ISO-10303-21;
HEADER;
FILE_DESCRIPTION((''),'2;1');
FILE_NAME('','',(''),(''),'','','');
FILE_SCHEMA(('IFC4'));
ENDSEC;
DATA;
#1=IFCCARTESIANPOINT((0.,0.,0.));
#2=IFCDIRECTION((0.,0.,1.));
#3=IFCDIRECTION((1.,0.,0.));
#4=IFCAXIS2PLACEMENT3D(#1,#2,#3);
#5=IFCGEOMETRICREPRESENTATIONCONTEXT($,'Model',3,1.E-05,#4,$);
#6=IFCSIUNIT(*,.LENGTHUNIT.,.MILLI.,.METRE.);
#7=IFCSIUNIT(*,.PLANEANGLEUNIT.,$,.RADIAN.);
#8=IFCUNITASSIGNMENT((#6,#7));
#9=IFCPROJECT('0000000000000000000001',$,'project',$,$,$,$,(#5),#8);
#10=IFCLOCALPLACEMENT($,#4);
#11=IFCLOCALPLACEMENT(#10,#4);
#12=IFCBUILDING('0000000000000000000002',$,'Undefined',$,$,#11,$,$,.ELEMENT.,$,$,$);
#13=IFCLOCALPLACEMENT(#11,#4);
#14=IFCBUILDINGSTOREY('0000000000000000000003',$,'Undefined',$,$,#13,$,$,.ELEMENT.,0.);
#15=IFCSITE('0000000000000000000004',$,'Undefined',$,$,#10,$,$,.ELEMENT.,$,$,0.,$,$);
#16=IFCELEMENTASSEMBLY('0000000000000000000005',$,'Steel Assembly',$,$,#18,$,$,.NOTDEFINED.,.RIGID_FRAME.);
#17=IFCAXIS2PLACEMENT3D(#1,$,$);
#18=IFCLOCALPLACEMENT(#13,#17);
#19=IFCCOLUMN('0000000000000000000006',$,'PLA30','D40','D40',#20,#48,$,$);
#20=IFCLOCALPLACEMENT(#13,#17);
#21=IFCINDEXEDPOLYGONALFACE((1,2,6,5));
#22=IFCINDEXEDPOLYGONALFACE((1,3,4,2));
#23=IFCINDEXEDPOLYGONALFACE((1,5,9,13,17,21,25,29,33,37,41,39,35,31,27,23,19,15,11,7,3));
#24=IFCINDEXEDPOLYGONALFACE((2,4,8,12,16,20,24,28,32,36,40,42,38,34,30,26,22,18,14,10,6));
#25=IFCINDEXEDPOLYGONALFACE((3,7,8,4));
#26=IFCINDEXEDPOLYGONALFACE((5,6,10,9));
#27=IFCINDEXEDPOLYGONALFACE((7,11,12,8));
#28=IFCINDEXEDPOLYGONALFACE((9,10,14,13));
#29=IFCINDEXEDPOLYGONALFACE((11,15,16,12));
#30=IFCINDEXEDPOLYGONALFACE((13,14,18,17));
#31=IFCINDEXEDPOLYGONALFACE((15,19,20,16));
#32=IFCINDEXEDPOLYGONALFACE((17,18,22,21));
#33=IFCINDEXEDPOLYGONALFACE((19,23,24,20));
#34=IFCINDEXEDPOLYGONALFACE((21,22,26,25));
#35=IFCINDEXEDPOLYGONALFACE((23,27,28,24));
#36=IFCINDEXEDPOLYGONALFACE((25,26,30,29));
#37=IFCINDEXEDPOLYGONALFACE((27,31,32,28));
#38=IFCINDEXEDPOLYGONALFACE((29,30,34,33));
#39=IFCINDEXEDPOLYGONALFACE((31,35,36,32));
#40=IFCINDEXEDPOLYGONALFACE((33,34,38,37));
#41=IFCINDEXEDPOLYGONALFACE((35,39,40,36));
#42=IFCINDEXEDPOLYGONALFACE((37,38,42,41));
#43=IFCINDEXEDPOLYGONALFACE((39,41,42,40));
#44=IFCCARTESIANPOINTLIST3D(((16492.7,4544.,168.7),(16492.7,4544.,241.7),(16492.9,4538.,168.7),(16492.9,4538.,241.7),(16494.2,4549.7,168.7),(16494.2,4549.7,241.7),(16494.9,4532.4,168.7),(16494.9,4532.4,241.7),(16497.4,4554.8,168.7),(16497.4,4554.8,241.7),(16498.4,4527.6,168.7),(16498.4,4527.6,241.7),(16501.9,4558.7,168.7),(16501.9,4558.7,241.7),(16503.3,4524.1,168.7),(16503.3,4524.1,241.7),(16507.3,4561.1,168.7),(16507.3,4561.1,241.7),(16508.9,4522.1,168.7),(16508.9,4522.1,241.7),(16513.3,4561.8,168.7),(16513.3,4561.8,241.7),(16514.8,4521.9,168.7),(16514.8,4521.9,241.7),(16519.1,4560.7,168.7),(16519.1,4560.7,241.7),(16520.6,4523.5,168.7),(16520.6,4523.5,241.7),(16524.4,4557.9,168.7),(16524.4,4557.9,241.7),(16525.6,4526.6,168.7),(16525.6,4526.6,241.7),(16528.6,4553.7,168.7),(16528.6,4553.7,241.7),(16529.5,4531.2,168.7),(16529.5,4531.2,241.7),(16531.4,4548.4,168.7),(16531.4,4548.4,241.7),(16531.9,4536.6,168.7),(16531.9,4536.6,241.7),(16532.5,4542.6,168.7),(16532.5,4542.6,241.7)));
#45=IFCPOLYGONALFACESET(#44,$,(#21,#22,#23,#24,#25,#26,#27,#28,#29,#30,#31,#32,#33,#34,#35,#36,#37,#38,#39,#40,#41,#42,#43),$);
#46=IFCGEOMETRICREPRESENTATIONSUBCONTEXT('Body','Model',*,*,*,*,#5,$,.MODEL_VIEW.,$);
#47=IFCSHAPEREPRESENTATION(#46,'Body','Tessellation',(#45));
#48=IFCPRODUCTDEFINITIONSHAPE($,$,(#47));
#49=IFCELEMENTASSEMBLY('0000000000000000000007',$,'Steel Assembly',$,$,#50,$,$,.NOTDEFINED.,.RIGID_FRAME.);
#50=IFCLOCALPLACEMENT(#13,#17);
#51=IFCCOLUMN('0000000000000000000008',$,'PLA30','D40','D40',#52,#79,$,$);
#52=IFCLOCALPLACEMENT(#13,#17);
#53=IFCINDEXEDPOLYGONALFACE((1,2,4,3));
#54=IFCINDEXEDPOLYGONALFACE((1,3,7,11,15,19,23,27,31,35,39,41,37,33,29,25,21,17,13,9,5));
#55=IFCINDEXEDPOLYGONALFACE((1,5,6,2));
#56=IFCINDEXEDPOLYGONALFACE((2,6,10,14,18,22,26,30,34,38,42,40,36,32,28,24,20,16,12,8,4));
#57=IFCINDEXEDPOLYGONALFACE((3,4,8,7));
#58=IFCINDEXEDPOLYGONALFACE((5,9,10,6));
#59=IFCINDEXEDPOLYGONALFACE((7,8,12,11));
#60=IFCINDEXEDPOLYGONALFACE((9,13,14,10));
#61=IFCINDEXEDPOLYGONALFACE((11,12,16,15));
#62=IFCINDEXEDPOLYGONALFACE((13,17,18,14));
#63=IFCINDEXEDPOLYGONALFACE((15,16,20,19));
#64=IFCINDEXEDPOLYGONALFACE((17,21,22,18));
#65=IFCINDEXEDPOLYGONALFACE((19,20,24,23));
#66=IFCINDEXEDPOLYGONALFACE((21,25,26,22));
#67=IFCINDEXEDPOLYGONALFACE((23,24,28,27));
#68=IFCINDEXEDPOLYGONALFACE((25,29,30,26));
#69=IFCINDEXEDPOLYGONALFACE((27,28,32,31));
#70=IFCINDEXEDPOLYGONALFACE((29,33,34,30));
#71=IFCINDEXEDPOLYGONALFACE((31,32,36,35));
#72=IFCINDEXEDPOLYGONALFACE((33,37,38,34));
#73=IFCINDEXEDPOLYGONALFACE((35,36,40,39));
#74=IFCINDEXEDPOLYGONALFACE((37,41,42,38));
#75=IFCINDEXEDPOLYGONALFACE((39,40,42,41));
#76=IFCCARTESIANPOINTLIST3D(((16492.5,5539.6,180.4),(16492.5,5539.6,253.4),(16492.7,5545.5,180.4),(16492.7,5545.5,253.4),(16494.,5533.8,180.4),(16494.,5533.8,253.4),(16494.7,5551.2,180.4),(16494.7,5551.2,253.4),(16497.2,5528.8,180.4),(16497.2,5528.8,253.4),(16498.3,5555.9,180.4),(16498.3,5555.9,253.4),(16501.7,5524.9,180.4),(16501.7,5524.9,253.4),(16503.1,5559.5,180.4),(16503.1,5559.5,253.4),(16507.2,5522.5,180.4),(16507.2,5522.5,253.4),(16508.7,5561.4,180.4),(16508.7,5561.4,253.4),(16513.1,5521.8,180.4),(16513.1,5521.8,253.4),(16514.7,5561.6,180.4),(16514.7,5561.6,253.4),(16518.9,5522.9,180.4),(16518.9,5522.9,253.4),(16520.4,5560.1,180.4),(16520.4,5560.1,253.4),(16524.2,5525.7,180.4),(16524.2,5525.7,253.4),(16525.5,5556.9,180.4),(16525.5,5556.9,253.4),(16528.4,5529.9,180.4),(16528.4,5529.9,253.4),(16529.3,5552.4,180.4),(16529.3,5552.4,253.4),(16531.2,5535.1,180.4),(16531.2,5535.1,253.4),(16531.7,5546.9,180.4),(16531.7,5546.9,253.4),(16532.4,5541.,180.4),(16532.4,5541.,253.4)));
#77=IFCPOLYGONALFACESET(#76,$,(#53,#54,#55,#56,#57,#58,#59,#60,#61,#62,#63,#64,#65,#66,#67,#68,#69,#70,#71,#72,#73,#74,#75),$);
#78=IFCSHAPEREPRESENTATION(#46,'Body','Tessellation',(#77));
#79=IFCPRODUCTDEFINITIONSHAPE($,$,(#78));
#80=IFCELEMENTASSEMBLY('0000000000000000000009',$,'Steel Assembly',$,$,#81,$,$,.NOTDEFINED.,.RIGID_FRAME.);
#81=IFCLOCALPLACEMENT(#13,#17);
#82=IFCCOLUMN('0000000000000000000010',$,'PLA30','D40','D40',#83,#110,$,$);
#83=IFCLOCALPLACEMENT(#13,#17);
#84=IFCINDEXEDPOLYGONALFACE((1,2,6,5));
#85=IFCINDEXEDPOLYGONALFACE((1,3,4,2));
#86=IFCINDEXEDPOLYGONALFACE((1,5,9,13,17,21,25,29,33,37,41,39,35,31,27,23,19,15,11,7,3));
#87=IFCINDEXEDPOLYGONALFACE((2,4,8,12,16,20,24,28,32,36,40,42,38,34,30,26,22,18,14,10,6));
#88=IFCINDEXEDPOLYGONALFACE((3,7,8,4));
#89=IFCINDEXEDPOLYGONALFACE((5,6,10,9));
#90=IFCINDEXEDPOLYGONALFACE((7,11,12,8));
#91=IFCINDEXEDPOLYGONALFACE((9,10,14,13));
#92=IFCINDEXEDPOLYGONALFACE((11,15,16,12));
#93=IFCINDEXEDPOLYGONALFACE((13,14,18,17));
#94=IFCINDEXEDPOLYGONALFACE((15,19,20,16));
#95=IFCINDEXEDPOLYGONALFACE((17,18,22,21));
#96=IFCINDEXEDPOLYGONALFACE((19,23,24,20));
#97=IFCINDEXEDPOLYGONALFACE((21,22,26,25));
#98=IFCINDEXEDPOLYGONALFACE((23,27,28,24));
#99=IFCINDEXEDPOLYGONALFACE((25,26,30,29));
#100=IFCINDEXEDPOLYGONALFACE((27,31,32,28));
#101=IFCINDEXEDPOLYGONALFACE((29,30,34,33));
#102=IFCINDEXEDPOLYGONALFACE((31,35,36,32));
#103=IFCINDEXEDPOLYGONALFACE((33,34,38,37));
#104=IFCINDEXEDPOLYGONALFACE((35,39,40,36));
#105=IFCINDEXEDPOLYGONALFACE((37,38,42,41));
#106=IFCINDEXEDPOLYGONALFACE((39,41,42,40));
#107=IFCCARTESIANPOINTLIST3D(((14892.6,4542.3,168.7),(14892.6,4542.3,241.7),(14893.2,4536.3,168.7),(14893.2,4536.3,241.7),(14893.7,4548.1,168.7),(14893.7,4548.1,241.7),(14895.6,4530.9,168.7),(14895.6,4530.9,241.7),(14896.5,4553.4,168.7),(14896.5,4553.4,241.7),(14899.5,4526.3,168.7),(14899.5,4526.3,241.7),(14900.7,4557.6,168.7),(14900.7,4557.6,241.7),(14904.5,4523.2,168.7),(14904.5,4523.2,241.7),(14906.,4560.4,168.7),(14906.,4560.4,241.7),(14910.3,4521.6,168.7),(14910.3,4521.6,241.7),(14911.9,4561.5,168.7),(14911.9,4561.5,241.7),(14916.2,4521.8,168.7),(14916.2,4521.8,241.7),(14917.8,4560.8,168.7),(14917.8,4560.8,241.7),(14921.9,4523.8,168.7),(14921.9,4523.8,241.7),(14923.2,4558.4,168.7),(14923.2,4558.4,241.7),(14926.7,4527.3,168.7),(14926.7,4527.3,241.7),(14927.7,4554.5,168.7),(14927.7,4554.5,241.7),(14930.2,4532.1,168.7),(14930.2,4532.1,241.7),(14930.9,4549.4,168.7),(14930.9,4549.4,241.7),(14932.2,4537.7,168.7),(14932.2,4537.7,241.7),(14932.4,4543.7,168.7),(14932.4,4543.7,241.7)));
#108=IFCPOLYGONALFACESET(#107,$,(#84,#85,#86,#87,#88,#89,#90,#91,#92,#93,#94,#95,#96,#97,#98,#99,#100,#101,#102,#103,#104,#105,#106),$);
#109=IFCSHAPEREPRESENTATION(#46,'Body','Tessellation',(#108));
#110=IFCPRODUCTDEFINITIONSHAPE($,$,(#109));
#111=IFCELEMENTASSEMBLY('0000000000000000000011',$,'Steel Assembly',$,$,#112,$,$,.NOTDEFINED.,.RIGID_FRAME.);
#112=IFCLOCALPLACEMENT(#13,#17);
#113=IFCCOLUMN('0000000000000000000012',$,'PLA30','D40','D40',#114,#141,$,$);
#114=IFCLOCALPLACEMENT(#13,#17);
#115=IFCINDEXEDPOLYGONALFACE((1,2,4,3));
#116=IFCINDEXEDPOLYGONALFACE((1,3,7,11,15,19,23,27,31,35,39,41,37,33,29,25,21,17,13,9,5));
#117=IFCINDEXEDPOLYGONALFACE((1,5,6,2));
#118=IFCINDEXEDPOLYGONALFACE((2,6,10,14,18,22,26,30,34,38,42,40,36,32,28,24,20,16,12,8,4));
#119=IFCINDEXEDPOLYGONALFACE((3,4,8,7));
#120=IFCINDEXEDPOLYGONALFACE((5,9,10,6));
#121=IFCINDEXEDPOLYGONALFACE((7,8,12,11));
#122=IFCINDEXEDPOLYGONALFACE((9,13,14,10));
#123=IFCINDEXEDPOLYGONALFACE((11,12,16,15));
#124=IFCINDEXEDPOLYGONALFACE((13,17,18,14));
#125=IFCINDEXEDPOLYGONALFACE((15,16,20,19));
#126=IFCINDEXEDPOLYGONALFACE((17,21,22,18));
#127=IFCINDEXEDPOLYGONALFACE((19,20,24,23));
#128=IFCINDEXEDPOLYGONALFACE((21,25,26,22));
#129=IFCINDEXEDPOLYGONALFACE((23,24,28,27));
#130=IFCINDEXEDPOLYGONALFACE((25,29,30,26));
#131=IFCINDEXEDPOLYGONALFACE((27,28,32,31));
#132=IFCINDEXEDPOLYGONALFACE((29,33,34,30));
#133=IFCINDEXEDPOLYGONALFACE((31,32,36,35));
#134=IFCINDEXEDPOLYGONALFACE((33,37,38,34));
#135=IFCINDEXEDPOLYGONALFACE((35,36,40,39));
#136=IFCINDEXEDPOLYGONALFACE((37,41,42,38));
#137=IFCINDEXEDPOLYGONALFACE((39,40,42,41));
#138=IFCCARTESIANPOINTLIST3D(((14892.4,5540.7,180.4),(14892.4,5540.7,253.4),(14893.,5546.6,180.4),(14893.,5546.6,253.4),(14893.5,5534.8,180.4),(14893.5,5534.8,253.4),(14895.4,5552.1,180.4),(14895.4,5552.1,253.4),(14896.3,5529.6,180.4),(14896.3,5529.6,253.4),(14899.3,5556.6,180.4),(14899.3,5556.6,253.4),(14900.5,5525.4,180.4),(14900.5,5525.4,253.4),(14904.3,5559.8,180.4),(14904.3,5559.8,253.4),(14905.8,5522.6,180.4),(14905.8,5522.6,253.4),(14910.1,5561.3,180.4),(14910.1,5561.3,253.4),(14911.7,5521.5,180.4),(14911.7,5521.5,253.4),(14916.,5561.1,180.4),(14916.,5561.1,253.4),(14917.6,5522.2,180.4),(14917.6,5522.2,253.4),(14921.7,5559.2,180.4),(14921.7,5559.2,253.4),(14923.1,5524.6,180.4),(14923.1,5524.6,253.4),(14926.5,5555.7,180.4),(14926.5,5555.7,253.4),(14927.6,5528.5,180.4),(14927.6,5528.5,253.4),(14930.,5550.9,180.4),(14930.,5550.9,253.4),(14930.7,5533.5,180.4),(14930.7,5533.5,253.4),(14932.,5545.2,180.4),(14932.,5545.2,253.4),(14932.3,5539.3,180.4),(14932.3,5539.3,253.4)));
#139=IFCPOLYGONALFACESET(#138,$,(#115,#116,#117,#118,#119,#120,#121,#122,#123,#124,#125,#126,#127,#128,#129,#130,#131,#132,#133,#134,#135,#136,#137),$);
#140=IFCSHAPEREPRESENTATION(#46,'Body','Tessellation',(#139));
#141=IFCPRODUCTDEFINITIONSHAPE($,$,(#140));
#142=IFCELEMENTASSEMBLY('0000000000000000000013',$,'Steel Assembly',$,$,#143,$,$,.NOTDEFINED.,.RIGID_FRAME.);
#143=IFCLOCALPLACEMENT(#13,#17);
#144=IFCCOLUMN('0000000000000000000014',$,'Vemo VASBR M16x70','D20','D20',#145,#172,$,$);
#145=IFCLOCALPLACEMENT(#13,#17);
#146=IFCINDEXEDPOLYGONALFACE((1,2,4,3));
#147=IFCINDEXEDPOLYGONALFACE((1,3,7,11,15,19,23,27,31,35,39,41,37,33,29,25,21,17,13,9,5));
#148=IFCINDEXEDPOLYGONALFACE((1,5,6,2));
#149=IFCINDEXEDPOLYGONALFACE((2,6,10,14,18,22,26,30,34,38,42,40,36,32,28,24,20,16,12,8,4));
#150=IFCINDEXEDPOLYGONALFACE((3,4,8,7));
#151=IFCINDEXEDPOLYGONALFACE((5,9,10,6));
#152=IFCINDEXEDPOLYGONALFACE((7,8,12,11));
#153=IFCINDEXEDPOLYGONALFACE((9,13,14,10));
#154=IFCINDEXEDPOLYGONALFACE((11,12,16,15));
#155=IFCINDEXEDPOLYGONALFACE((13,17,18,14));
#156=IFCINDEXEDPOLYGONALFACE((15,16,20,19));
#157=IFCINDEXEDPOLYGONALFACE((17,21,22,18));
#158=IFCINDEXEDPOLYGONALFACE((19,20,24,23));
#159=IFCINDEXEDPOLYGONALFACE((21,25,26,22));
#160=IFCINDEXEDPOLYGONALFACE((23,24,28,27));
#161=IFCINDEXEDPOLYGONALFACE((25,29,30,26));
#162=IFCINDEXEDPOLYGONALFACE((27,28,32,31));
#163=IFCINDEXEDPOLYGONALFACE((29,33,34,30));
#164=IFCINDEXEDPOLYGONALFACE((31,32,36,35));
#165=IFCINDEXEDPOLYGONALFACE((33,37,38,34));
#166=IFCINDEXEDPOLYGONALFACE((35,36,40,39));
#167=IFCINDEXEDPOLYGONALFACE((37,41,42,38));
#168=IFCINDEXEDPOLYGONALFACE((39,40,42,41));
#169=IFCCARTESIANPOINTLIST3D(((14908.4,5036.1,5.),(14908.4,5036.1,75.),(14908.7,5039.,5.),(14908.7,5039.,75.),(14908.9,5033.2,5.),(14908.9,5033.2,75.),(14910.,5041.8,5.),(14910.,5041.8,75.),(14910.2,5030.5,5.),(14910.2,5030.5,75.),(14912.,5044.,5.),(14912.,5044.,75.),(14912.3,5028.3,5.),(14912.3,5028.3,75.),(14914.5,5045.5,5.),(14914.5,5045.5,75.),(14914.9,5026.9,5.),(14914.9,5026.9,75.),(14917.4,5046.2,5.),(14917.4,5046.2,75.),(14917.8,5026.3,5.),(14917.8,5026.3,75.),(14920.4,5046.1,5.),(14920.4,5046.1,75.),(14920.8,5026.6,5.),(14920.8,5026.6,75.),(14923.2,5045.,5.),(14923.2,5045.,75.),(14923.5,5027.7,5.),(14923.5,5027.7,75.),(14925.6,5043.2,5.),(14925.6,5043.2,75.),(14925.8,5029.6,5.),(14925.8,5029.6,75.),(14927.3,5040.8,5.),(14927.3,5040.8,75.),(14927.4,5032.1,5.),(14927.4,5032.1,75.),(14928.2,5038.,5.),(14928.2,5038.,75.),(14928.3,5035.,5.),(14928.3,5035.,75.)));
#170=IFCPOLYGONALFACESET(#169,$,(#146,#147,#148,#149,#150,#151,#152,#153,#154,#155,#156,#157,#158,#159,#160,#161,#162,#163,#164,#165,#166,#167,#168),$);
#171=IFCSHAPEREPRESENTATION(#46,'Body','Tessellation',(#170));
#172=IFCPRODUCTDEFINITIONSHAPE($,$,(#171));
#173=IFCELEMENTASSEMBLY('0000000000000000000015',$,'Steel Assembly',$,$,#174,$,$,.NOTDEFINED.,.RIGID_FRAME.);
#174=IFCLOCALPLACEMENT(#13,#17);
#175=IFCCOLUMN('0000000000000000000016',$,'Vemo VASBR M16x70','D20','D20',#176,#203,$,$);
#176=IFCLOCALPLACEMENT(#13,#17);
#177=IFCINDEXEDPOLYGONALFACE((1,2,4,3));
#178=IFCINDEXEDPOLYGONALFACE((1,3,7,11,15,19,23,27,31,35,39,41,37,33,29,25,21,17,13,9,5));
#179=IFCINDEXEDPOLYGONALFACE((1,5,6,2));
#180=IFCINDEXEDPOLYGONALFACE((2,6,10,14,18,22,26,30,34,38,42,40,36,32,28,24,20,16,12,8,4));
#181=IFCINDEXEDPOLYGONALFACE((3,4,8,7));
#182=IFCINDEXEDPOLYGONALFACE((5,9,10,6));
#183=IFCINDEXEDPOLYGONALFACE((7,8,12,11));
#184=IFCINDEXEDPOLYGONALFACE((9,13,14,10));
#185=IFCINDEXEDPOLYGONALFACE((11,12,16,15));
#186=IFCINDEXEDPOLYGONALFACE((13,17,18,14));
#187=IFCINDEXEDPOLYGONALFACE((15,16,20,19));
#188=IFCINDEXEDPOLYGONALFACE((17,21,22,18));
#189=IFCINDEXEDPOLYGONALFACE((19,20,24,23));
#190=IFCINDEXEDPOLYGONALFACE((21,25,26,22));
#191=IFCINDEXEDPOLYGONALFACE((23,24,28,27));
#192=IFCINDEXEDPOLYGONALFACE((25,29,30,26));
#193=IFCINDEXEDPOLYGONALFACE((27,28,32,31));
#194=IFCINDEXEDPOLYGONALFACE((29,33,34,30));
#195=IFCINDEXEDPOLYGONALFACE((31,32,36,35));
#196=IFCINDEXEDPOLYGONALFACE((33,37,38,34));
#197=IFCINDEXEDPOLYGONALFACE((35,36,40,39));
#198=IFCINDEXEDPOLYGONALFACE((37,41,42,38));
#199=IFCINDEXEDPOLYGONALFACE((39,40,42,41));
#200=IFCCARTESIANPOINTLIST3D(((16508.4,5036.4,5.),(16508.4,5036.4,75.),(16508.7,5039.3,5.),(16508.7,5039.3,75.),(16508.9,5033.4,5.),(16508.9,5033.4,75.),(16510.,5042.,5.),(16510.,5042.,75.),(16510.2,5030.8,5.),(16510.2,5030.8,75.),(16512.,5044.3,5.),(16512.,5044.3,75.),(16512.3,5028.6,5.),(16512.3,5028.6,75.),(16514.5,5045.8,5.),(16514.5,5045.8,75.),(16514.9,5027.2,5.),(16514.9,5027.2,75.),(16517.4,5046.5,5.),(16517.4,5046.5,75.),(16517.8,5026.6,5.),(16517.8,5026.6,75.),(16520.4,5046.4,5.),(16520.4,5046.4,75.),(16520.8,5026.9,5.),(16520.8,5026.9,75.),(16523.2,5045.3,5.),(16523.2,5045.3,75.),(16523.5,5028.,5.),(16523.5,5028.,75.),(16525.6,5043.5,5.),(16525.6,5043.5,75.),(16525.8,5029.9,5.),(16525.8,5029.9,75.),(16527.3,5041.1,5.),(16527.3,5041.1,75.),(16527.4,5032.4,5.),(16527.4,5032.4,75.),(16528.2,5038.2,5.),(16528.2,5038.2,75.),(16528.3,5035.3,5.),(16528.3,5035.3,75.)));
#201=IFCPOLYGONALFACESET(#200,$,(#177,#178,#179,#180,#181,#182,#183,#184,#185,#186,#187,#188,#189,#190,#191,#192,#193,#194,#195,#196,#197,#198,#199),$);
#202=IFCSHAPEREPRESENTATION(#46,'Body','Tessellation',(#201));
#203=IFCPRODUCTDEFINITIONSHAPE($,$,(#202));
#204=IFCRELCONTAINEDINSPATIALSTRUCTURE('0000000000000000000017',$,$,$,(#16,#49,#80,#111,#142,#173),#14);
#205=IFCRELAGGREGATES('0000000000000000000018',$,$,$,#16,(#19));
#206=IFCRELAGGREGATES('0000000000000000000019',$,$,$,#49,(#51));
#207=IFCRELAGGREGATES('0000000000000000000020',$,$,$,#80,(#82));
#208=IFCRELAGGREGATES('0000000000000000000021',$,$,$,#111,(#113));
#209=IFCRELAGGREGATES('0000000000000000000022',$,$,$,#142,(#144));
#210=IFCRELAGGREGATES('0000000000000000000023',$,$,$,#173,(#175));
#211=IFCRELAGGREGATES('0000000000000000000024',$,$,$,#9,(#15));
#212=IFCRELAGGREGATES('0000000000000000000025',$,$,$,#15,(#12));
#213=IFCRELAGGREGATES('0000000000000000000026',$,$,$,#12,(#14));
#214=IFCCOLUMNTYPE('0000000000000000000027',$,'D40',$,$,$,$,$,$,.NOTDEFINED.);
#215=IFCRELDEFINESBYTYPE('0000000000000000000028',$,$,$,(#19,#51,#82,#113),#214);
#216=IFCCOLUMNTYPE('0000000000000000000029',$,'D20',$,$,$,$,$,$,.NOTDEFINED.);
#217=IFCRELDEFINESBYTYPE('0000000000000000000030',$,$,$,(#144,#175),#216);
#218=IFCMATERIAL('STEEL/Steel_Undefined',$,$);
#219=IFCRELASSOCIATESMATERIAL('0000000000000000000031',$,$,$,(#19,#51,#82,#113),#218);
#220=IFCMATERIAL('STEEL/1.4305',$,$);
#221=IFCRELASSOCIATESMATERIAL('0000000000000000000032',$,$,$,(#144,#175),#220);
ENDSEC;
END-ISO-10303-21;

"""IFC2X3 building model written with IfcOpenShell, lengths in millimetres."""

from ifc_helpers import new_model, si_unit, frame, origin_with_axes, origin_2d_with_axis, place, context, subcontext, project, spatial, circle, extrude, material, type_object, element, aggregate, save


model = new_model("IFC2X3")

# Units and contexts
model_context = context("Model", 3, precision=1e-05, world=origin_with_axes())
body_context = subcontext(model_context, "Body", "Model", "MODEL_VIEW")
ifc_project = project(units=[si_unit("LENGTHUNIT", "METRE", prefix="MILLI"), si_unit("PLANEANGLEUNIT", "RADIAN")], contexts=[model_context])

# Site, building, storey
site_placement = place(None, origin_with_axes())
site = spatial("IfcSite", under=ifc_project, at=site_placement, Name="Undefined", CompositionType="ELEMENT", RefElevation=0.0)
building_placement = place(site_placement, origin_with_axes())
building = spatial("IfcBuilding", under=site, at=building_placement, Name="Undefined", CompositionType="ELEMENT")
storey_placement = place(building_placement, origin_with_axes())
storey = spatial("IfcBuildingStorey", under=building, at=storey_placement, Name="Undefined", CompositionType="ELEMENT", Elevation=0.0)

# Element assemblies, columns
assembly_1_placement = place(storey_placement, origin_with_axes())
assembly_1 = element("IfcElementAssembly", 1, at=assembly_1_placement, inside=storey, Name="Steel Assembly", AssemblyPlace="NOTDEFINED", PredefinedType="RIGID_FRAME")
ifc_material_1 = material(Name="STEEL/Steel_Undefined")
column_type_1 = type_object("IfcColumnType", Name="D40", PredefinedType="NOTDEFINED")
column_1_placement = place(assembly_1_placement, frame((16512.6, 4541.8, 168.7), z_axis=(0.0, 0.0, 1.0), x_axis=(-0.529844, -0.848095, 0.0)))
column_1 = element("IfcColumn", 2, at=column_1_placement, type_object=column_type_1, material=ifc_material_1, Name="PLA30", Description="D40", ObjectType="D40", context=body_context, shape_type="SweptSolid", body=[
    extrude(circle(Radius=20.0, at=origin_2d_with_axis()), frame((0.0, 0.0, 73.0), z_axis=(0.0, 0.0, -1.0), x_axis=(0.0, 1.0, 0.0)), (0.0, 0.0, 1.0), 73.0),
])
assembly_2_placement = place(storey_placement, origin_with_axes())
assembly_2 = element("IfcElementAssembly", 3, at=assembly_2_placement, inside=storey, Name="Steel Assembly", AssemblyPlace="NOTDEFINED", PredefinedType="RIGID_FRAME")
column_2_placement = place(assembly_2_placement, frame((16512.4, 5541.8, 180.4), z_axis=(0.0, 0.0, 1.0), x_axis=(0.530154, -0.847901, 0.0)))
column_2 = element("IfcColumn", 4, at=column_2_placement, type_object=column_type_1, material=ifc_material_1, Name="PLA30", Description="D40", ObjectType="D40", context=body_context, shape_type="SweptSolid", body=[
    extrude(circle(Radius=20.0, at=origin_2d_with_axis()), frame((0.0, 0.0, 73.0), z_axis=(0.0, 0.0, -1.0), x_axis=(0.0, 1.0, 0.0)), (0.0, 0.0, 1.0), 73.0),
])
assembly_3_placement = place(storey_placement, origin_with_axes())
assembly_3 = element("IfcElementAssembly", 5, at=assembly_3_placement, inside=storey, Name="Steel Assembly", AssemblyPlace="NOTDEFINED", PredefinedType="RIGID_FRAME")
column_3_placement = place(assembly_3_placement, frame((14912.6, 4541.5, 168.7), z_axis=(0.0, 0.0, 1.0), x_axis=(-0.530154, 0.847901, 0.0)))
column_3 = element("IfcColumn", 6, at=column_3_placement, type_object=column_type_1, material=ifc_material_1, Name="PLA30", Description="D40", ObjectType="D40", context=body_context, shape_type="SweptSolid", body=[
    extrude(circle(Radius=20.0, at=origin_2d_with_axis()), frame((0.0, 0.0, 73.0), z_axis=(0.0, 0.0, -1.0), x_axis=(0.0, 1.0, 0.0)), (0.0, 0.0, 1.0), 73.0),
])
assembly_4_placement = place(storey_placement, origin_with_axes())
assembly_4 = element("IfcElementAssembly", 7, at=assembly_4_placement, inside=storey, Name="Steel Assembly", AssemblyPlace="NOTDEFINED", PredefinedType="RIGID_FRAME")
column_4_placement = place(assembly_4_placement, frame((14912.4, 5541.5, 180.4), z_axis=(0.0, 0.0, 1.0), x_axis=(0.529844, 0.848095, 0.0)))
column_4 = element("IfcColumn", 8, at=column_4_placement, type_object=column_type_1, material=ifc_material_1, Name="PLA30", Description="D40", ObjectType="D40", context=body_context, shape_type="SweptSolid", body=[
    extrude(circle(Radius=20.0, at=origin_2d_with_axis()), frame((0.0, 0.0, 73.0), z_axis=(0.0, 0.0, -1.0), x_axis=(0.0, 1.0, 0.0)), (0.0, 0.0, 1.0), 73.0),
])
assembly_5_placement = place(storey_placement, origin_with_axes())
assembly_5 = element("IfcElementAssembly", 9, at=assembly_5_placement, inside=storey, Name="Steel Assembly", AssemblyPlace="NOTDEFINED", PredefinedType="RIGID_FRAME")
ifc_material_2 = material(Name="STEEL/1.4305")
column_type_2 = type_object("IfcColumnType", Name="D20", PredefinedType="NOTDEFINED")
column_5_placement = place(assembly_5_placement, frame((14918.4, 5036.3, 5.0), z_axis=(0.0, 0.0, 1.0), x_axis=(-0.018576, 0.999827, 0.0)))
column_5 = element("IfcColumn", 10, at=column_5_placement, type_object=column_type_2, material=ifc_material_2, Name="Vemo VASBR M16x70", Description="D20", ObjectType="D20", context=body_context, shape_type="SweptSolid", body=[
    extrude(circle(Radius=10.0, at=origin_2d_with_axis()), frame((0.0, 0.0, 70.0), z_axis=(0.0, 0.0, -1.0), x_axis=(0.0, 1.0, 0.0)), (0.0, 0.0, 1.0), 70.0),
])
assembly_6_placement = place(storey_placement, origin_with_axes())
assembly_6 = element("IfcElementAssembly", 11, at=assembly_6_placement, inside=storey, Name="Steel Assembly", AssemblyPlace="NOTDEFINED", PredefinedType="RIGID_FRAME")
column_6_placement = place(assembly_6_placement, frame((16518.4, 5036.6, 5.0), z_axis=(0.0, 0.0, 1.0), x_axis=(-0.018576, 0.999827, 0.0)))
column_6 = element("IfcColumn", 12, at=column_6_placement, type_object=column_type_2, material=ifc_material_2, Name="Vemo VASBR M16x70", Description="D20", ObjectType="D20", context=body_context, shape_type="SweptSolid", body=[
    extrude(circle(Radius=10.0, at=origin_2d_with_axis()), frame((0.0, 0.0, 70.0), z_axis=(0.0, 0.0, -1.0), x_axis=(0.0, 1.0, 0.0)), (0.0, 0.0, 1.0), 70.0),
])

aggregate(assembly_1, [column_1])
aggregate(assembly_2, [column_2])
aggregate(assembly_3, [column_3])
aggregate(assembly_4, [column_4])

aggregate(assembly_5, [column_5])
aggregate(assembly_6, [column_6])

save(model, "model.ifc")
